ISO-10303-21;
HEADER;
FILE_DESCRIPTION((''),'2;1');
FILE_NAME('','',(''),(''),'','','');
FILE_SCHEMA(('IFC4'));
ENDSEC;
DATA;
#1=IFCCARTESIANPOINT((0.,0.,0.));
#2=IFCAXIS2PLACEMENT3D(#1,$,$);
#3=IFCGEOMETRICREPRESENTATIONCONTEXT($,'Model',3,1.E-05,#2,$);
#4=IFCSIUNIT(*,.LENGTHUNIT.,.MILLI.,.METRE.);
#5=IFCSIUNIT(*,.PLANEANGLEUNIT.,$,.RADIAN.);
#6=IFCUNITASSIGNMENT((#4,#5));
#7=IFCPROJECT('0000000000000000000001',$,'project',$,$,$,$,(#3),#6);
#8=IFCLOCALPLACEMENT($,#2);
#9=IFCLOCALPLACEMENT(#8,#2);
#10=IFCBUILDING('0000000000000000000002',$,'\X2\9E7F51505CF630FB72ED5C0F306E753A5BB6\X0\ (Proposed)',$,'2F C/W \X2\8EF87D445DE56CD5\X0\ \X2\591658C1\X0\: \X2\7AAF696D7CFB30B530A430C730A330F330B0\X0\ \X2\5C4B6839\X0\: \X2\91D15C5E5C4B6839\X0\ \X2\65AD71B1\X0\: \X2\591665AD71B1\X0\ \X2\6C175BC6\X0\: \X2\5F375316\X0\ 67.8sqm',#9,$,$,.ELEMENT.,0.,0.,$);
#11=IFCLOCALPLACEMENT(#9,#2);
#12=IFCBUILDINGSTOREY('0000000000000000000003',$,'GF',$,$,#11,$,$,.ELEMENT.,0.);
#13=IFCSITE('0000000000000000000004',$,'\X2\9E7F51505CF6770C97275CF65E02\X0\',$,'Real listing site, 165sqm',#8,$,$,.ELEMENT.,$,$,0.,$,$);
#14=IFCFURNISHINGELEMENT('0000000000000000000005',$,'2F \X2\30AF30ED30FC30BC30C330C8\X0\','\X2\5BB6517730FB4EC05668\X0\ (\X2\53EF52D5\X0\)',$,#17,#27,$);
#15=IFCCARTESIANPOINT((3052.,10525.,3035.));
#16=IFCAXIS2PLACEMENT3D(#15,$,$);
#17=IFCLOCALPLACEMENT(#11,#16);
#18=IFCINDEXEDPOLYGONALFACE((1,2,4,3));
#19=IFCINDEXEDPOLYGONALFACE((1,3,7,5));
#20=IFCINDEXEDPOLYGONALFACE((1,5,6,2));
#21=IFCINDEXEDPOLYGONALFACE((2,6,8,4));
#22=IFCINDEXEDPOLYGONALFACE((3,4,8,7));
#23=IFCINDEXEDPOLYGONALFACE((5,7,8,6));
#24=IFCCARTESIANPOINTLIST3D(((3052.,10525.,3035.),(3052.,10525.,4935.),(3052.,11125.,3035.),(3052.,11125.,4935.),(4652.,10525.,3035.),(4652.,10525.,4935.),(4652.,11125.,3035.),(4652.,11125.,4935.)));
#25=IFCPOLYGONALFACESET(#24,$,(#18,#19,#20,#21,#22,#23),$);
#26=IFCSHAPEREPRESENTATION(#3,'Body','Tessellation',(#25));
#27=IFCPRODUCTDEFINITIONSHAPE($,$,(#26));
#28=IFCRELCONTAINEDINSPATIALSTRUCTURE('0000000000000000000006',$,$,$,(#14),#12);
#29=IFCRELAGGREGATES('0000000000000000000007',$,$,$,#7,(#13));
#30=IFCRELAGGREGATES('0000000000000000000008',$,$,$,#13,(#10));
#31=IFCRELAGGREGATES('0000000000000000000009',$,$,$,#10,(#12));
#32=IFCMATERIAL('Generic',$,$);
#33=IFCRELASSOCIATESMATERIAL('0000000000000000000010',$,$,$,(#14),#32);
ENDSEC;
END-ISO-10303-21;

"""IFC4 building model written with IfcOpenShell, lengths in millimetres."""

from ifc_helpers import new_model, si_unit, frame, frame_2d, origin, place, context, project, spatial, rectangle, extrude, material, element, save


model = new_model("IFC4")

# Units and contexts
model_context = context("Model", 3, precision=1e-05, world=origin())
ifc_project = project(units=[si_unit("LENGTHUNIT", "METRE", prefix="MILLI"), si_unit("PLANEANGLEUNIT", "RADIAN")], contexts=[model_context])

# Site, building, storey
site_placement = place(None, origin())
site = spatial("IfcSite", under=ifc_project, at=site_placement, Name="鹿児島県霧島市", ObjectType="Real listing site, 165sqm", CompositionType="ELEMENT", RefElevation=0.0)
building_placement = place(site_placement, origin())
building = spatial("IfcBuilding", under=site, at=building_placement, Name="鹿児島・狭小の町家 (Proposed)", ObjectType="2F C/W 軸組工法 外壁: 窯業系サイディング 屋根: 金属屋根 断熱: 外断熱 気密: 強化 67.8sqm", CompositionType="ELEMENT", ElevationOfRefHeight=0.0, ElevationOfTerrain=0.0)
storey_placement = place(building_placement, origin())
storey = spatial("IfcBuildingStorey", under=building, at=storey_placement, Name="GF", CompositionType="ELEMENT", Elevation=0.0)

# Shared definitions
ifc_material_1 = material(Name="Generic")

# Furnishing element
furnishing_placement = place(storey_placement, frame((3052.0, 10525.0, 3035.0)))
element("IfcFurnishingElement", 1, at=furnishing_placement, inside=storey, material=ifc_material_1, Name="2F クローゼット", Description="家具・什器 (可動)", context=model_context, shape_type="SweptSolid", body=[
    extrude(rectangle(XDim=1600.0, YDim=600.0, at=frame_2d((800.0, 300.0))), frame((3052.0, 10525.0, 3035.0)), (0.0, 0.0, 1.0), 1900.0),
])

save(model, "model.ifc")
